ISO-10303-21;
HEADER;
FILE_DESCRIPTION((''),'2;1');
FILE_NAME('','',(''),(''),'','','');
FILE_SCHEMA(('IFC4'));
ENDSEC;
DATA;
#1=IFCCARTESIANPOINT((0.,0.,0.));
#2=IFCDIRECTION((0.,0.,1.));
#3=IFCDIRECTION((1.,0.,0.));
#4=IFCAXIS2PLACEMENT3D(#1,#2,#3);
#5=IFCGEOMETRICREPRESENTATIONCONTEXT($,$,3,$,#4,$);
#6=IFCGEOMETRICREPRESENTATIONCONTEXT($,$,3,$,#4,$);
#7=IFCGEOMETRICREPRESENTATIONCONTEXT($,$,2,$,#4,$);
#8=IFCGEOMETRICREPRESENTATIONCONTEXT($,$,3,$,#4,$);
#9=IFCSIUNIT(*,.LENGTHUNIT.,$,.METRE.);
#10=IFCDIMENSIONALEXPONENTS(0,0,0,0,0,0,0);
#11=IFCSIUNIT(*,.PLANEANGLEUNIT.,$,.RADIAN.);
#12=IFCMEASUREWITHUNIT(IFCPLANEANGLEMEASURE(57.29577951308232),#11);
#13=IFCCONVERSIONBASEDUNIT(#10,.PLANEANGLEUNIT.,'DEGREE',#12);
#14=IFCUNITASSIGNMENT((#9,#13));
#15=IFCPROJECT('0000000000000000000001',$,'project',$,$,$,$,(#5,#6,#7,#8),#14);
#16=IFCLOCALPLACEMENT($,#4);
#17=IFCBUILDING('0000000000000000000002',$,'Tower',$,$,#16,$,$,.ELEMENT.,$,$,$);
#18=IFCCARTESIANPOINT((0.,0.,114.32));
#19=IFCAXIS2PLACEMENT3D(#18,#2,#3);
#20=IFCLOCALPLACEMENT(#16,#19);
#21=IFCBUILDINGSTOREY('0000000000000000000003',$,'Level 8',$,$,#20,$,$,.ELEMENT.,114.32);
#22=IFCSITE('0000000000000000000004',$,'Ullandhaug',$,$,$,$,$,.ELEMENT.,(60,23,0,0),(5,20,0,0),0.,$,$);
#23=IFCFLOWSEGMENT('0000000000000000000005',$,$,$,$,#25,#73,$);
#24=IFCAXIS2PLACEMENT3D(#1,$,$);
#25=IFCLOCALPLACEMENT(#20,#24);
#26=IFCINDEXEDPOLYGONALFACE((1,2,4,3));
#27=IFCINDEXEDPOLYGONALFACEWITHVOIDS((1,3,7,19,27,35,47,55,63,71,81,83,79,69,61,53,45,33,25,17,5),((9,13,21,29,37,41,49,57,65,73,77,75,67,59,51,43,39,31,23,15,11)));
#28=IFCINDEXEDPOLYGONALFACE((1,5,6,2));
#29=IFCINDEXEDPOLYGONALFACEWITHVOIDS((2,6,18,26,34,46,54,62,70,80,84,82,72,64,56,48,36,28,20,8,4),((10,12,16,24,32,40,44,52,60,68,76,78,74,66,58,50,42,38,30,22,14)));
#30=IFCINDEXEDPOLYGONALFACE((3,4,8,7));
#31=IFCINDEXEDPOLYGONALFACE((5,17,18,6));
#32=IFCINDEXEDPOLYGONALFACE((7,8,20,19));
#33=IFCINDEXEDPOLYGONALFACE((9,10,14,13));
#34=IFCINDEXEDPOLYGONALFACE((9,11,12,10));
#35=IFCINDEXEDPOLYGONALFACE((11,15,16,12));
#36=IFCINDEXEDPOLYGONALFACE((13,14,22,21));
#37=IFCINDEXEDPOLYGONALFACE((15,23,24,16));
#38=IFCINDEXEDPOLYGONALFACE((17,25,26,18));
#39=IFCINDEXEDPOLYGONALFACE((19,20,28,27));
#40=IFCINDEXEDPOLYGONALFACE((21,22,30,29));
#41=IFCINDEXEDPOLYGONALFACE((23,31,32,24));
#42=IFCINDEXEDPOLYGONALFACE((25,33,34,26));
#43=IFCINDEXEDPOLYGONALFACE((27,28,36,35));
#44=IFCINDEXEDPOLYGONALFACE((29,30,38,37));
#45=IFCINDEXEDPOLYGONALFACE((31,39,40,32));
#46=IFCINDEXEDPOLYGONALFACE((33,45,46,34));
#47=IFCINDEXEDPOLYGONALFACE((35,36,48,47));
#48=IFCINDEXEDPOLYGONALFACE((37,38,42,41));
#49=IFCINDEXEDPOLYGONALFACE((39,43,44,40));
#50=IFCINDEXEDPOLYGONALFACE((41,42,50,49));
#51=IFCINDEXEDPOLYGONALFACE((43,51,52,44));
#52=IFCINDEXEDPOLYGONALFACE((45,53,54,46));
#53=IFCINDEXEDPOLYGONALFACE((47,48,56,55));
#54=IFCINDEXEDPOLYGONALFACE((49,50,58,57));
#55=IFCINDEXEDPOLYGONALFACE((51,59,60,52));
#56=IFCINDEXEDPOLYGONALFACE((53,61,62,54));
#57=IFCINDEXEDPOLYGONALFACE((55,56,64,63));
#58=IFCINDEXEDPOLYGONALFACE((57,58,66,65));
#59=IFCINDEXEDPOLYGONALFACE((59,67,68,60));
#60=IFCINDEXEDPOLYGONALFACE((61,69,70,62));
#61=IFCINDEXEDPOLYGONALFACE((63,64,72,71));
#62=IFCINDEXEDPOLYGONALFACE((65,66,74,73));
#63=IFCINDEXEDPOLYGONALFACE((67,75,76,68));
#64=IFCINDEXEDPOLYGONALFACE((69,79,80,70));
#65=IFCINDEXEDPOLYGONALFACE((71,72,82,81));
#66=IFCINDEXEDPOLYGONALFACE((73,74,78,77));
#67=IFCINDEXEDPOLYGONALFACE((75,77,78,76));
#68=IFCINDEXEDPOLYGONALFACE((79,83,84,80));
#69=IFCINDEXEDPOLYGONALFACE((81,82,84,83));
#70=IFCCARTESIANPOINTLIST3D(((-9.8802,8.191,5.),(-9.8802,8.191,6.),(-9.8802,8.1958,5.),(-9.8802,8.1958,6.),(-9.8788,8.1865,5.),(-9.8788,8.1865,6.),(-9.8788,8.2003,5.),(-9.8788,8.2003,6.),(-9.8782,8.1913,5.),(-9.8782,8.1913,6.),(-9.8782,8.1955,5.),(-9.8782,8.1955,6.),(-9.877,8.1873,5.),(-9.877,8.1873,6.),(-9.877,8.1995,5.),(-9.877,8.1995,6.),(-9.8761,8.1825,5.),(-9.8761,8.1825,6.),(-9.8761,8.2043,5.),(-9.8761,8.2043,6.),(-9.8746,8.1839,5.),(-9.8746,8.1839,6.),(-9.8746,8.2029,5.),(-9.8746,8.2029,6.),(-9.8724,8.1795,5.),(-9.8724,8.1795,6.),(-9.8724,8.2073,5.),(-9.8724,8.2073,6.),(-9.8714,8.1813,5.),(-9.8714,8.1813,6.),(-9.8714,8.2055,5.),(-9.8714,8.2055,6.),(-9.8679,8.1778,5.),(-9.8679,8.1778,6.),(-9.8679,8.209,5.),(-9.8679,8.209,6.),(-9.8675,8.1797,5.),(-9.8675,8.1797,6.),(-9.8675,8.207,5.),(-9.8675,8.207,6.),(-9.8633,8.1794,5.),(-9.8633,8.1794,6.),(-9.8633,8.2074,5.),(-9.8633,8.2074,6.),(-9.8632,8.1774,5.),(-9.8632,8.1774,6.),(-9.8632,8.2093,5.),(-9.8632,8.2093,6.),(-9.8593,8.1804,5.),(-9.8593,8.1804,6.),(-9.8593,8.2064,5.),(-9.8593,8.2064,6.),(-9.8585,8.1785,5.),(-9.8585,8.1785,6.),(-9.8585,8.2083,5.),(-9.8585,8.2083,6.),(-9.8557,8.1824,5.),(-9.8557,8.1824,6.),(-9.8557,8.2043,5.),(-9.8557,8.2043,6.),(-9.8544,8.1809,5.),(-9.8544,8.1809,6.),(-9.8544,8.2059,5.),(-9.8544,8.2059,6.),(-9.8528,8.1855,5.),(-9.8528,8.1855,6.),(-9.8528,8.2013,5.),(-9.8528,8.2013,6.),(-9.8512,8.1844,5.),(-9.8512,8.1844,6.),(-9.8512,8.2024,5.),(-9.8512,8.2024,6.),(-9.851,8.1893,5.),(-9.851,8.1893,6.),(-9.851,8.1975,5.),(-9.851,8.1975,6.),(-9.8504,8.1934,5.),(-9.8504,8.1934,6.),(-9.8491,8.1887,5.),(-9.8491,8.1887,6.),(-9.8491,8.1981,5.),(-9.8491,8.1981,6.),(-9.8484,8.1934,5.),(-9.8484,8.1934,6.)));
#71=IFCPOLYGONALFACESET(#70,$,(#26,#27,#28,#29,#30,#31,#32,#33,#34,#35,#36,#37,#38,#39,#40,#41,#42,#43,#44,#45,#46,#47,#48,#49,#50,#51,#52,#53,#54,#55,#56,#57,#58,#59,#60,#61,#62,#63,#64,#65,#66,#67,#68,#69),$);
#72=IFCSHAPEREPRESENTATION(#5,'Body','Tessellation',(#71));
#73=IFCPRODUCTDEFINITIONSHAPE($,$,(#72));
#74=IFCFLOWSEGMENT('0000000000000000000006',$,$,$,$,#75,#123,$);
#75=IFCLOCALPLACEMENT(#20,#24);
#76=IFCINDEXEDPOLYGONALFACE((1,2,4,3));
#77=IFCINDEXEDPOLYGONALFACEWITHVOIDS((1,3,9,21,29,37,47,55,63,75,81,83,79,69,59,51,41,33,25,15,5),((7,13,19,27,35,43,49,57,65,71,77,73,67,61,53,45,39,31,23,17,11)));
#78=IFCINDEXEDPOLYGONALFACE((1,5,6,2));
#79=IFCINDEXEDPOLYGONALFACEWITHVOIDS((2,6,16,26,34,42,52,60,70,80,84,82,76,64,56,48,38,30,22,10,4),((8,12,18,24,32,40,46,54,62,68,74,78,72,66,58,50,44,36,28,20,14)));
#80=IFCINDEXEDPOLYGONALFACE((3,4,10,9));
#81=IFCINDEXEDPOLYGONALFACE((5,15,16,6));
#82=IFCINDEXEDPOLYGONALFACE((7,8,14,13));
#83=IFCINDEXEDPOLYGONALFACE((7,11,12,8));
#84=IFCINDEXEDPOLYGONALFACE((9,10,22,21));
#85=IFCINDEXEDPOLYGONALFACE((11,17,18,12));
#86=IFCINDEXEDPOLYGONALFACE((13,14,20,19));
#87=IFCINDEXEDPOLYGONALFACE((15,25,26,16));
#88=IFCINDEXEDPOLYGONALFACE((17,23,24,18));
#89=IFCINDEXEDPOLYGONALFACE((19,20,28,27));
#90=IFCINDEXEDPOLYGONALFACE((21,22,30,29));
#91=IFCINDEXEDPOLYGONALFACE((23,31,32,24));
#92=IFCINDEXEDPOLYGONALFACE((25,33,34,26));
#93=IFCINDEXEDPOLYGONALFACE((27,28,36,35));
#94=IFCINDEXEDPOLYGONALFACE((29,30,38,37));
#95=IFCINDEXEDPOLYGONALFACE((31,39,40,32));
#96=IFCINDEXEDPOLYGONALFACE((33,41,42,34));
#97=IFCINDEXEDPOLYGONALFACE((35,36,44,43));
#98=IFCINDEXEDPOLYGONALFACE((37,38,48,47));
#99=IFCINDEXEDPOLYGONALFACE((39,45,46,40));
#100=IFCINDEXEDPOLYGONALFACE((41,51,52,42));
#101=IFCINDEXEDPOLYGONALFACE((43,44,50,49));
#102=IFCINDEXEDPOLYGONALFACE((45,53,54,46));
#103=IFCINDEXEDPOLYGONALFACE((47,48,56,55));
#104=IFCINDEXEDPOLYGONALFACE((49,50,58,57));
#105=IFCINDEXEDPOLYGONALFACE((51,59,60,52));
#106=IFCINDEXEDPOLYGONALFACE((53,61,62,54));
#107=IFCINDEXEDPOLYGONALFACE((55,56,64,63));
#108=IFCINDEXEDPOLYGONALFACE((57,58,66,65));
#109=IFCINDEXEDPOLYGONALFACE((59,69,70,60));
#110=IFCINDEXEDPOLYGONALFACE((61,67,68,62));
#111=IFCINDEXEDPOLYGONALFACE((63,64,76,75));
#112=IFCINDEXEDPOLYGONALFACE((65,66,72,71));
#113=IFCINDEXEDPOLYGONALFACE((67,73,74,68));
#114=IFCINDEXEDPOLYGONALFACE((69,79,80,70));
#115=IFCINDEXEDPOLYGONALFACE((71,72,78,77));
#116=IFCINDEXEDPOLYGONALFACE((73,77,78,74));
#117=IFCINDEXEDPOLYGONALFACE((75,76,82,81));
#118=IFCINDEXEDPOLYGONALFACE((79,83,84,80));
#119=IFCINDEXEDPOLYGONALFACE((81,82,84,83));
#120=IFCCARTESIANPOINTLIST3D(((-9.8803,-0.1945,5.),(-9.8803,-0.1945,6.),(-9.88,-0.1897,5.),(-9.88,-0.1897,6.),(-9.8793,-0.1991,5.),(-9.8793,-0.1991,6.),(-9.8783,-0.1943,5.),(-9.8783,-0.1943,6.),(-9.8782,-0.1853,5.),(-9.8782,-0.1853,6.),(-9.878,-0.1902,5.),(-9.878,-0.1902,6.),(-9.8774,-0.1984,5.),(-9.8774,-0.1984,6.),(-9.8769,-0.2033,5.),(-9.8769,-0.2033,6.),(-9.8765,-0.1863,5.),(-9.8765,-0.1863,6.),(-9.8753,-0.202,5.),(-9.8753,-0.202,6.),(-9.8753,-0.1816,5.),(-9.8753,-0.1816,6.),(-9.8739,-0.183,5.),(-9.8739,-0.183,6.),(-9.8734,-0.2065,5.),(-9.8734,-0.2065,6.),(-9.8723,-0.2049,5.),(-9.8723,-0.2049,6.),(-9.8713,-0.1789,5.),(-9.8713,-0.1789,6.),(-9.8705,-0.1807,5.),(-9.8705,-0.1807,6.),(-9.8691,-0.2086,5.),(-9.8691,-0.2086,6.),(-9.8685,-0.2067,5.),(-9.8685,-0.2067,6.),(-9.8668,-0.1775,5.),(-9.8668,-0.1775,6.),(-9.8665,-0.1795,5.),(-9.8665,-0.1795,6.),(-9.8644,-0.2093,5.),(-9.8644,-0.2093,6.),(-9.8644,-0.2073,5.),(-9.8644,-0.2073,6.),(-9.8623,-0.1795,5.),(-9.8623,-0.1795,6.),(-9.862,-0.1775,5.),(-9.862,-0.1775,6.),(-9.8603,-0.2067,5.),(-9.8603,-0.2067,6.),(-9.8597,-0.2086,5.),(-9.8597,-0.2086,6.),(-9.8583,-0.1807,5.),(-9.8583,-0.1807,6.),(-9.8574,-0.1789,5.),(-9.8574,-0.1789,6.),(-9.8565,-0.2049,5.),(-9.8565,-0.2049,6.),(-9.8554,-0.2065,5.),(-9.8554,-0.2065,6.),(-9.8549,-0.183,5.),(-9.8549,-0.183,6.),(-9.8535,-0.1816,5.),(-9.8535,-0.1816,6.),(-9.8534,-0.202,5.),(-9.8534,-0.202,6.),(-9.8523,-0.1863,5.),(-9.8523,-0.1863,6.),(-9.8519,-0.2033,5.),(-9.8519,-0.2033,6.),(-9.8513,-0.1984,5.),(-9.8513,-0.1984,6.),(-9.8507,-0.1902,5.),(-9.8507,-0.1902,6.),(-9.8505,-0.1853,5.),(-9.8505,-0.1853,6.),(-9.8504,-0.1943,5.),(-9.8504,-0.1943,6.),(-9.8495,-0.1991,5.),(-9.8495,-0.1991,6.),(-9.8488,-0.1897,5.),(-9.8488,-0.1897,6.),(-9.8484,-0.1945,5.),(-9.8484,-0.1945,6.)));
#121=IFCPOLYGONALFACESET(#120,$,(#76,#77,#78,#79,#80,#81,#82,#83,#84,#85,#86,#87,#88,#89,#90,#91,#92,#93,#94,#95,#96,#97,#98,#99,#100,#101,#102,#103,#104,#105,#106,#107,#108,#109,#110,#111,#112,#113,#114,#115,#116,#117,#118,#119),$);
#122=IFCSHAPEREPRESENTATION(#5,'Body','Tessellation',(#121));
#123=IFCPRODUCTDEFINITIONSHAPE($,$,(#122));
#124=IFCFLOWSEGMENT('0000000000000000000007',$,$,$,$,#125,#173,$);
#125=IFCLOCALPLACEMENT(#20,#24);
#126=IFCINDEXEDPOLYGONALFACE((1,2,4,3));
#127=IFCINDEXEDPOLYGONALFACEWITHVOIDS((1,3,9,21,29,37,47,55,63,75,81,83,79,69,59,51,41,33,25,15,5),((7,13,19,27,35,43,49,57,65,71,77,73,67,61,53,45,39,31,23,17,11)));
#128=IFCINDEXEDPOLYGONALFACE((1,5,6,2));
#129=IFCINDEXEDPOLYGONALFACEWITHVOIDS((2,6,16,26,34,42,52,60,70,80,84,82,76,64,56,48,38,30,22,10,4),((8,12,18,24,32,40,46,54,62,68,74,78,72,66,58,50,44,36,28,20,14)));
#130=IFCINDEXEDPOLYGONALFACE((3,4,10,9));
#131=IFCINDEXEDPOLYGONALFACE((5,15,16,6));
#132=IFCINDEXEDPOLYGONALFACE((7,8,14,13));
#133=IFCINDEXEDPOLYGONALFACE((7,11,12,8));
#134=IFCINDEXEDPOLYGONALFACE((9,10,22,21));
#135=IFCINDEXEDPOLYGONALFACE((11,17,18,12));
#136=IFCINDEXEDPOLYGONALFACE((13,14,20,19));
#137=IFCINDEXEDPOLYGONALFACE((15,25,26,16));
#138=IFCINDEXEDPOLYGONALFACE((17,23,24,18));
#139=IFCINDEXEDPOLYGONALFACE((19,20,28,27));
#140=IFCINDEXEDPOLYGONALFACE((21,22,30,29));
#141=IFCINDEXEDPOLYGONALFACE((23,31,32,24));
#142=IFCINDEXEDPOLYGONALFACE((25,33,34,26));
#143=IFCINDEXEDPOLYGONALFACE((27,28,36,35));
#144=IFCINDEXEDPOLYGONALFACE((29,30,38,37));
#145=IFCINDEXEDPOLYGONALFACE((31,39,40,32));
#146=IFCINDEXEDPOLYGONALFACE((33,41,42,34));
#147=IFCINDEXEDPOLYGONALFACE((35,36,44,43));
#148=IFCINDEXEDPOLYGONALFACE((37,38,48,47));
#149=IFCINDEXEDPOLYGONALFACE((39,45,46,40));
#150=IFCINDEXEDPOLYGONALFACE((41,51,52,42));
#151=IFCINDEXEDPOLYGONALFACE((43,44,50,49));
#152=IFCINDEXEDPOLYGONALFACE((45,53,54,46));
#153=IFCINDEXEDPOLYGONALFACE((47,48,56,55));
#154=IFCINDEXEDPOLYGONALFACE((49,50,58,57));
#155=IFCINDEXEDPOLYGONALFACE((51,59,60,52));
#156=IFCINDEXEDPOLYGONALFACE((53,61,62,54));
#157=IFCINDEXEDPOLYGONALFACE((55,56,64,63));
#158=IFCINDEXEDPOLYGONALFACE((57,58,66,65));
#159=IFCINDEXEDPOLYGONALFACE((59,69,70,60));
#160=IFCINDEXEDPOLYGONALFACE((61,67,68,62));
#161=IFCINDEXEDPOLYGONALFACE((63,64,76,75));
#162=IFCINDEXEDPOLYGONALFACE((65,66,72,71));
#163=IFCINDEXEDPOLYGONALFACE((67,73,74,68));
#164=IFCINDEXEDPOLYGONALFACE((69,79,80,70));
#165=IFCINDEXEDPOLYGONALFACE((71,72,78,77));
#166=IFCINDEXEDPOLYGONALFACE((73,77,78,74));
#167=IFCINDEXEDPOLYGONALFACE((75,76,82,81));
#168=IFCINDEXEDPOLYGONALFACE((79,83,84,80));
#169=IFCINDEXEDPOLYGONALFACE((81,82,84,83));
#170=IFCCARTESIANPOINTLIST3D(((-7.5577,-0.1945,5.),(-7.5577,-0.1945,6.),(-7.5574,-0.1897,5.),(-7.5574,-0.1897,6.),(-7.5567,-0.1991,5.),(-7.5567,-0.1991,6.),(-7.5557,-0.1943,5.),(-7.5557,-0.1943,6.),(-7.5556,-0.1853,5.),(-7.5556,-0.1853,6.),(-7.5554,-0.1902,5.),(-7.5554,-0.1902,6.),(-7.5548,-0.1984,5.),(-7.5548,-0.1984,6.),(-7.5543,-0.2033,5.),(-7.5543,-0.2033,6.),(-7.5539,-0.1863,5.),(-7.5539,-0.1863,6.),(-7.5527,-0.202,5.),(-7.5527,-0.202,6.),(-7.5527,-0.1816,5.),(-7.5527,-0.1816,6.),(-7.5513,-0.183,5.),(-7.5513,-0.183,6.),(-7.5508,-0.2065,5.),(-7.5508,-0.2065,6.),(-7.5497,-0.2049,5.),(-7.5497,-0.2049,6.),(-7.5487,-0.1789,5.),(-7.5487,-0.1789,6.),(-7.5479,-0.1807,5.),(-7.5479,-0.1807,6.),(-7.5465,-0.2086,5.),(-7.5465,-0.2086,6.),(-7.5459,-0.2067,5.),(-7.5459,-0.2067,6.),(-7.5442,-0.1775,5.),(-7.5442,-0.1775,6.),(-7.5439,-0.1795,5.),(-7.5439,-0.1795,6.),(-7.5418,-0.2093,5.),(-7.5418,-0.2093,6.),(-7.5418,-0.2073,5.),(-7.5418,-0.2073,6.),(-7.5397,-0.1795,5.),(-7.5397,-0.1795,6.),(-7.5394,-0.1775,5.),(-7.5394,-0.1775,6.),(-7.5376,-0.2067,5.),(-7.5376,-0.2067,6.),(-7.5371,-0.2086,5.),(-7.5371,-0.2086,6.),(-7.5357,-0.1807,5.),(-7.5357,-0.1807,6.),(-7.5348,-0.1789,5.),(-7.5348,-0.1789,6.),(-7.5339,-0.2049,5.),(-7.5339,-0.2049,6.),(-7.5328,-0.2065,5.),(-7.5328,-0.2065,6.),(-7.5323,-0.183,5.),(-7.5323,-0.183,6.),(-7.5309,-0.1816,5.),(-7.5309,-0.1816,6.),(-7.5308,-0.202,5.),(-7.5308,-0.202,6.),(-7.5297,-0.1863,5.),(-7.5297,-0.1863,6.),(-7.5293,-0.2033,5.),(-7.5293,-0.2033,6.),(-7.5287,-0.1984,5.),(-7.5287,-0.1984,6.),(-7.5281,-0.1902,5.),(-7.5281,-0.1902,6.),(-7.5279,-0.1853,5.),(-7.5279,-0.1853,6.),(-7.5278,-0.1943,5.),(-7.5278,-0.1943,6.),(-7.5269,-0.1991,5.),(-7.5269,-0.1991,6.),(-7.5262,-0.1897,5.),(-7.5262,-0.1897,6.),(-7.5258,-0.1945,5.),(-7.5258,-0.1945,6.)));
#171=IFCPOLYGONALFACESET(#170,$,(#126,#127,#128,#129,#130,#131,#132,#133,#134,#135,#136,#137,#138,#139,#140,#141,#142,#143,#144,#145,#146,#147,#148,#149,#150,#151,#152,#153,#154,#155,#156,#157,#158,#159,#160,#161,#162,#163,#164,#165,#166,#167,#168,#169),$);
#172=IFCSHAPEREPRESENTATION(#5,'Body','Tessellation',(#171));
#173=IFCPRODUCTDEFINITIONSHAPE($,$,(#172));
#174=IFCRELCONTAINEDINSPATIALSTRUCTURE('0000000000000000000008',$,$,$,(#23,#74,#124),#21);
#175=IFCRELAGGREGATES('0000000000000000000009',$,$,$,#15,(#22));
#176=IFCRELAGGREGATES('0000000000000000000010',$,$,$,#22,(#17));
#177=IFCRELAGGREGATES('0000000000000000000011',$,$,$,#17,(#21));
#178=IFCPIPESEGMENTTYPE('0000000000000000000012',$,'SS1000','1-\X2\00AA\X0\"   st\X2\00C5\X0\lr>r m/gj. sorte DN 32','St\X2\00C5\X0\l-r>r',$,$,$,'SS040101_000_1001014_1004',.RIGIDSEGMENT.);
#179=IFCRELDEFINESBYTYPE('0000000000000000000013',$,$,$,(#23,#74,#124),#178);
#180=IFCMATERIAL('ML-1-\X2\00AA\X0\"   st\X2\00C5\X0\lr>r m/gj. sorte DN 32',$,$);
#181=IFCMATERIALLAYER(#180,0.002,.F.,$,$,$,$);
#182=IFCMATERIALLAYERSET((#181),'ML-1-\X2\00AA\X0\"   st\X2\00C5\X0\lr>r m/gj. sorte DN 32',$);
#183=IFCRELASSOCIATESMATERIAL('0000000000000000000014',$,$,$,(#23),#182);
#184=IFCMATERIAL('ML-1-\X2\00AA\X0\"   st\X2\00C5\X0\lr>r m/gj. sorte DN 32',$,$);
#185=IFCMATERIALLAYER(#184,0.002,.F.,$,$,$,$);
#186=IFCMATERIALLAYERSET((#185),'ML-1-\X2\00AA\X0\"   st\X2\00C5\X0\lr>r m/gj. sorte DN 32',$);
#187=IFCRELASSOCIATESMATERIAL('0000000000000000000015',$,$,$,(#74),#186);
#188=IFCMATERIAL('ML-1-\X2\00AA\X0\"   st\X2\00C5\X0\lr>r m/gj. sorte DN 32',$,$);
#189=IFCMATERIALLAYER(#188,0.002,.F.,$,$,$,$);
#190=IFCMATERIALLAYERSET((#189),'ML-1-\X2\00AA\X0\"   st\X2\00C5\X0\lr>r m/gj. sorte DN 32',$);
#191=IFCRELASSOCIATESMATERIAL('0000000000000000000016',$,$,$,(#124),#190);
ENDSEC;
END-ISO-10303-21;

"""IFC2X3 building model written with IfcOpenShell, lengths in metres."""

from ifc_helpers import new_model, entity, si_unit, converted_unit, frame, origin_with_axes, origin_2d_with_axis, place, context, project, spatial, hollow_circle, extrude, material, layer, layer_set, layer_usage, type_object, element, save


model = new_model("IFC2X3")

# Units and contexts
context_of_model_1 = context(None, 3, world=origin_with_axes())
context_of_model_2 = context(None, 3, world=origin_with_axes())
context_of_model_3 = context(None, 2, world=origin_with_axes())
context_of_model_4 = context(None, 3, world=origin_with_axes())
ifc_project = project(units=[si_unit("LENGTHUNIT", "METRE"), converted_unit("PLANEANGLEUNIT", "DEGREE", entity("IfcPlaneAngleMeasure", 57.29577951308232), si_unit("PLANEANGLEUNIT", "RADIAN"), dimensions=[0, 0, 0, 0, 0, 0, 0])], contexts=[context_of_model_1, context_of_model_2, context_of_model_3, context_of_model_4])

# Site, building, storey
site = spatial("IfcSite", under=ifc_project, Name="Ullandhaug", CompositionType="ELEMENT", RefLatitude=(60, 23, 0, 0), RefLongitude=(5, 20, 0, 0), RefElevation=0.0)
building_placement = place(None, origin_with_axes())
building = spatial("IfcBuilding", under=site, at=building_placement, Name="Tower", CompositionType="ELEMENT")
storey_placement = place(building_placement, frame((0.0, 0.0, 114.32), z_axis=(0.0, 0.0, 1.0), x_axis=(1.0, 0.0, 0.0)))
storey = spatial("IfcBuildingStorey", under=building, at=storey_placement, Name="Level 8", CompositionType="ELEMENT", Elevation=114.32)

# Flow segments
pipe_segment_type_1 = type_object("IfcPipeSegmentType", Name="SS1000", Description="1-ª\"   stÅlr>r m/gj. sorte DN 32", ApplicableOccurrence="StÅl-r>r", ElementType="SS040101_000_1001014_1004", PredefinedType="RIGIDSEGMENT")
ifc_material_1 = material(Name="ML-1-ª\"   stÅlr>r m/gj. sorte DN 32")
ifc_layer_1 = layer(ifc_material_1, 0.002, ventilated=False)
ifc_layer_set_1 = layer_set([ifc_layer_1], Name="ML-1-ª\"   stÅlr>r m/gj. sorte DN 32")
ifc_layer_usage_1 = layer_usage(ifc_layer_set_1, "AXIS2", "POSITIVE", 0.0)
flow_segment_1_placement = place(storey_placement, frame((-9.8644, 8.1934, 5.0), z_axis=(0.0, 0.0, 1.0), x_axis=(1.0, 0.0, 0.0)))
element("IfcFlowSegment", 1, at=flow_segment_1_placement, inside=storey, type_object=pipe_segment_type_1, material=ifc_layer_usage_1, context=context_of_model_1, shape_type="SweptSolid", body=[
    extrude(hollow_circle(Radius=0.016, WallThickness=0.002, at=origin_2d_with_axis()), origin_with_axes(), (0.0, 0.0, 1.0), 1.0),
])
ifc_material_2 = material(Name="ML-1-ª\"   stÅlr>r m/gj. sorte DN 32")
ifc_layer_2 = layer(ifc_material_2, 0.002, ventilated=False)
ifc_layer_set_2 = layer_set([ifc_layer_2], Name="ML-1-ª\"   stÅlr>r m/gj. sorte DN 32")
ifc_layer_usage_2 = layer_usage(ifc_layer_set_2, "AXIS2", "POSITIVE", 0.0)
flow_segment_2_placement = place(storey_placement, frame((-9.8644, -0.1933, 5.0), z_axis=(0.0, 0.0, 1.0), x_axis=(0.0, -1.0, 0.0)))
element("IfcFlowSegment", 2, at=flow_segment_2_placement, inside=storey, type_object=pipe_segment_type_1, material=ifc_layer_usage_2, context=context_of_model_1, shape_type="SweptSolid", body=[
    extrude(hollow_circle(Radius=0.016, WallThickness=0.002, at=origin_2d_with_axis()), origin_with_axes(), (0.0, 0.0, 1.0), 1.0),
])
ifc_material_3 = material(Name="ML-1-ª\"   stÅlr>r m/gj. sorte DN 32")
ifc_layer_3 = layer(ifc_material_3, 0.002, ventilated=False)
ifc_layer_set_3 = layer_set([ifc_layer_3], Name="ML-1-ª\"   stÅlr>r m/gj. sorte DN 32")
ifc_layer_usage_3 = layer_usage(ifc_layer_set_3, "AXIS2", "POSITIVE", 0.0)
flow_segment_3_placement = place(storey_placement, frame((-7.5418, -0.1933, 5.0), z_axis=(0.0, 0.0, 1.0), x_axis=(0.0, -1.0, 0.0)))
element("IfcFlowSegment", 3, at=flow_segment_3_placement, inside=storey, type_object=pipe_segment_type_1, material=ifc_layer_usage_3, context=context_of_model_1, shape_type="SweptSolid", body=[
    extrude(hollow_circle(Radius=0.016, WallThickness=0.002, at=origin_2d_with_axis()), origin_with_axes(), (0.0, 0.0, 1.0), 1.0),
])

save(model, "model.ifc")
